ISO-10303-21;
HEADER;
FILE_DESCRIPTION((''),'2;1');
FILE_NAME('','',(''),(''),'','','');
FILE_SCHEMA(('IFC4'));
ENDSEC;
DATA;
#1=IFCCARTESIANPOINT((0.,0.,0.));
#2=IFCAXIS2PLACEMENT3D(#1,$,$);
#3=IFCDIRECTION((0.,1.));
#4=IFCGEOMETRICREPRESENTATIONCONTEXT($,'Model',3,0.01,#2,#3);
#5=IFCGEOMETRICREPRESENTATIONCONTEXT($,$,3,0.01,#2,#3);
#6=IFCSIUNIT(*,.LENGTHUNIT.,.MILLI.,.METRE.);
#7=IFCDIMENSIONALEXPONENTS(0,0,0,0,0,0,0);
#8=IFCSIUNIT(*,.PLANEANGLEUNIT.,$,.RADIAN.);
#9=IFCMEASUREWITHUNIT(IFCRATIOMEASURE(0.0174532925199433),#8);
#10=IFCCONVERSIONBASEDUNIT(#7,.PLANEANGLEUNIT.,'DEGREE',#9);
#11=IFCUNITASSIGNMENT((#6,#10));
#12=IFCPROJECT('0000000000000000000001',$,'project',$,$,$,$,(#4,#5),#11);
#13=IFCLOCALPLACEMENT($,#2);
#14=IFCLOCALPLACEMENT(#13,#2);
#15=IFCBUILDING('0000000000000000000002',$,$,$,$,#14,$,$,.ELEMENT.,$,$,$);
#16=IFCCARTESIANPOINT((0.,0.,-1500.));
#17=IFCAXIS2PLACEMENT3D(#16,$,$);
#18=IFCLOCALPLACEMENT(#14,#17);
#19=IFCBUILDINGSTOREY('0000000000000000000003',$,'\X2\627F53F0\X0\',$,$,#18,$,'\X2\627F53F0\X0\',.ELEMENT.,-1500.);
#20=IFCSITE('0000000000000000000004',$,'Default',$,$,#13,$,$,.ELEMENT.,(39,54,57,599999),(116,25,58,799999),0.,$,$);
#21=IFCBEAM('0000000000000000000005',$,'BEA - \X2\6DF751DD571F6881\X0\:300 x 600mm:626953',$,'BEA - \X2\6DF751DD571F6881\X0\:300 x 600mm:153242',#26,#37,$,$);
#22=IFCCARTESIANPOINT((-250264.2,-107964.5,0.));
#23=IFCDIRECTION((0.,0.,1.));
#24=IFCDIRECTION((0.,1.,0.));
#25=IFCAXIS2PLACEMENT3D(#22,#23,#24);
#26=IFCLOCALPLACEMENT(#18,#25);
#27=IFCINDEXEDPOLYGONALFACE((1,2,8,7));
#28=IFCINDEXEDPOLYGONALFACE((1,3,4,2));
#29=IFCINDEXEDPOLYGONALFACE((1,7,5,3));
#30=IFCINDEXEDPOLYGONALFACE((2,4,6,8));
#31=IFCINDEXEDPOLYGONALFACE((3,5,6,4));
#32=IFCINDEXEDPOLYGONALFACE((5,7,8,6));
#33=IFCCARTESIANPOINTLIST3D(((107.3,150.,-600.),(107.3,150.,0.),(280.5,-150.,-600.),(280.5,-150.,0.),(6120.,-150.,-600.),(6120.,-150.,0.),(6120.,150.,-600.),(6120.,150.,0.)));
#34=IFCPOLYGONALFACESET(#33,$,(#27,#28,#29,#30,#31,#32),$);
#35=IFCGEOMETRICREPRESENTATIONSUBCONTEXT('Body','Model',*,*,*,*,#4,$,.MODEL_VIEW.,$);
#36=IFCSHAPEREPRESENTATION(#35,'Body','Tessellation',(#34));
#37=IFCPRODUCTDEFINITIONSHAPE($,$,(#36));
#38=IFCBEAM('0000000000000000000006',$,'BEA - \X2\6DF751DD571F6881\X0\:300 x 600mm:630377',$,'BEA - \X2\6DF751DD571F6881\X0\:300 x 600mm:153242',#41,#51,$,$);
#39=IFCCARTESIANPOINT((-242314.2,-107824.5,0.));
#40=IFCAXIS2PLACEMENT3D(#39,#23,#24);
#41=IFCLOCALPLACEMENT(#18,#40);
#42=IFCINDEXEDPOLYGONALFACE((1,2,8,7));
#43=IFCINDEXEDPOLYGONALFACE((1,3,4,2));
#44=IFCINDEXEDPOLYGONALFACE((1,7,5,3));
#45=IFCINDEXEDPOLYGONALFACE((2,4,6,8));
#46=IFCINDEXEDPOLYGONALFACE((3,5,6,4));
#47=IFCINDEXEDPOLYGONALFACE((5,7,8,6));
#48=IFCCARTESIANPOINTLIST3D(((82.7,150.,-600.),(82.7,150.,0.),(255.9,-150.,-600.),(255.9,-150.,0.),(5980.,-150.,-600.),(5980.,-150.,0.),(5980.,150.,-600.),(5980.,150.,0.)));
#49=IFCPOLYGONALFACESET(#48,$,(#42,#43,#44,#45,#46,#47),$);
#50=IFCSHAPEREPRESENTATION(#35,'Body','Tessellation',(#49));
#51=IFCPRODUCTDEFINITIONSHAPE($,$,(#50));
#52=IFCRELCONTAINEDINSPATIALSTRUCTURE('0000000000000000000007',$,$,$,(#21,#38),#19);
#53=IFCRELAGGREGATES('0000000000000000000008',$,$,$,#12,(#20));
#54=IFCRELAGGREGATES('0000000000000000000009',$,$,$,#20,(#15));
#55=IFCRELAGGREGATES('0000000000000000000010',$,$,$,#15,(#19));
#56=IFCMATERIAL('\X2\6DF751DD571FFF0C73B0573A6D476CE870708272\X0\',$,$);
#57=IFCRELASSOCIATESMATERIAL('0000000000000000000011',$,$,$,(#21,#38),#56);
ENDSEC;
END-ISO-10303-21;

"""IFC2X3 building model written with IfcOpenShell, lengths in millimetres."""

from ifc_helpers import new_model, entity, si_unit, converted_unit, direction, frame, frame_2d, origin, place, context, subcontext, project, spatial, rectangle, extrude, clip, halfspace, material, element, save


model = new_model("IFC2X3")

# Units and contexts
model_context = context("Model", 3, precision=0.01, world=origin(), true_north=direction((0.0, 1.0)))
context_of_model = context(None, 3, precision=0.01, world=origin(), true_north=direction((0.0, 1.0)))
body_context = subcontext(model_context, "Body", "Model", "MODEL_VIEW")
ifc_project = project(units=[si_unit("LENGTHUNIT", "METRE", prefix="MILLI"), converted_unit("PLANEANGLEUNIT", "DEGREE", entity("IfcRatioMeasure", 0.0174532925199433), si_unit("PLANEANGLEUNIT", "RADIAN"), dimensions=[0, 0, 0, 0, 0, 0, 0])], contexts=[model_context, context_of_model])

# Site, building, storey
site_placement = place(None, origin())
site = spatial("IfcSite", under=ifc_project, at=site_placement, Name="Default", CompositionType="ELEMENT", RefLatitude=(39, 54, 57, 599999), RefLongitude=(116, 25, 58, 799999), RefElevation=0.0)
building_placement = place(site_placement, origin())
building = spatial("IfcBuilding", under=site, at=building_placement, CompositionType="ELEMENT")
storey_placement = place(building_placement, frame((0.0, 0.0, -1500.0)))
storey = spatial("IfcBuildingStorey", under=building, at=storey_placement, Name="承台", LongName="承台", CompositionType="ELEMENT", Elevation=-1500.0)

# Shared definitions
ifc_material_1 = material(Name="混凝土，现场浇注灰色")

# Beams
beam_1_placement = place(storey_placement, frame((-250264.2, -107964.5, 0.0), z_axis=(0.0, 0.0, 1.0), x_axis=(0.0, 1.0, 0.0)))
element("IfcBeam", 1, at=beam_1_placement, inside=storey, material=ifc_material_1, Name="BEA - 混凝土梁:300 x 600mm:626953", ObjectType="BEA - 混凝土梁:300 x 600mm:153242", context=body_context, shape_type="Clipping", body=[
    clip(extrude(rectangle(XDim=600.0, YDim=300.0, at=frame_2d((0.0, 0.0), x_axis=(1.0, 0.0))), frame((107.3, 0.0, -300.0), z_axis=(1.0, 0.0, 0.0), x_axis=(0.0, 0.0, -1.0)), (0.0, 0.0, 1.0), 6012.7), halfspace(frame((594.0, -693.3, 0.0), z_axis=(-0.866125, -0.499827, 0.0), x_axis=(0.499827, -0.866125, 0.0)), False)),
])
beam_2_placement = place(storey_placement, frame((-242314.2, -107824.5, 0.0), z_axis=(0.0, 0.0, 1.0), x_axis=(0.0, 1.0, 0.0)))
element("IfcBeam", 2, at=beam_2_placement, inside=storey, material=ifc_material_1, Name="BEA - 混凝土梁:300 x 600mm:630377", ObjectType="BEA - 混凝土梁:300 x 600mm:153242", context=body_context, shape_type="Clipping", body=[
    clip(extrude(rectangle(XDim=600.0, YDim=300.0, at=frame_2d((0.0, 0.0), x_axis=(1.0, 0.0))), frame((82.7, 0.0, -300.0), z_axis=(1.0, 0.0, 0.0), x_axis=(0.0, 0.0, -1.0)), (0.0, 0.0, 1.0), 5897.3), halfspace(frame((454.0, -493.3, 0.0), z_axis=(-0.866125, -0.499827, 0.0), x_axis=(0.499827, -0.866125, 0.0)), False)),
])

save(model, "model.ifc")
